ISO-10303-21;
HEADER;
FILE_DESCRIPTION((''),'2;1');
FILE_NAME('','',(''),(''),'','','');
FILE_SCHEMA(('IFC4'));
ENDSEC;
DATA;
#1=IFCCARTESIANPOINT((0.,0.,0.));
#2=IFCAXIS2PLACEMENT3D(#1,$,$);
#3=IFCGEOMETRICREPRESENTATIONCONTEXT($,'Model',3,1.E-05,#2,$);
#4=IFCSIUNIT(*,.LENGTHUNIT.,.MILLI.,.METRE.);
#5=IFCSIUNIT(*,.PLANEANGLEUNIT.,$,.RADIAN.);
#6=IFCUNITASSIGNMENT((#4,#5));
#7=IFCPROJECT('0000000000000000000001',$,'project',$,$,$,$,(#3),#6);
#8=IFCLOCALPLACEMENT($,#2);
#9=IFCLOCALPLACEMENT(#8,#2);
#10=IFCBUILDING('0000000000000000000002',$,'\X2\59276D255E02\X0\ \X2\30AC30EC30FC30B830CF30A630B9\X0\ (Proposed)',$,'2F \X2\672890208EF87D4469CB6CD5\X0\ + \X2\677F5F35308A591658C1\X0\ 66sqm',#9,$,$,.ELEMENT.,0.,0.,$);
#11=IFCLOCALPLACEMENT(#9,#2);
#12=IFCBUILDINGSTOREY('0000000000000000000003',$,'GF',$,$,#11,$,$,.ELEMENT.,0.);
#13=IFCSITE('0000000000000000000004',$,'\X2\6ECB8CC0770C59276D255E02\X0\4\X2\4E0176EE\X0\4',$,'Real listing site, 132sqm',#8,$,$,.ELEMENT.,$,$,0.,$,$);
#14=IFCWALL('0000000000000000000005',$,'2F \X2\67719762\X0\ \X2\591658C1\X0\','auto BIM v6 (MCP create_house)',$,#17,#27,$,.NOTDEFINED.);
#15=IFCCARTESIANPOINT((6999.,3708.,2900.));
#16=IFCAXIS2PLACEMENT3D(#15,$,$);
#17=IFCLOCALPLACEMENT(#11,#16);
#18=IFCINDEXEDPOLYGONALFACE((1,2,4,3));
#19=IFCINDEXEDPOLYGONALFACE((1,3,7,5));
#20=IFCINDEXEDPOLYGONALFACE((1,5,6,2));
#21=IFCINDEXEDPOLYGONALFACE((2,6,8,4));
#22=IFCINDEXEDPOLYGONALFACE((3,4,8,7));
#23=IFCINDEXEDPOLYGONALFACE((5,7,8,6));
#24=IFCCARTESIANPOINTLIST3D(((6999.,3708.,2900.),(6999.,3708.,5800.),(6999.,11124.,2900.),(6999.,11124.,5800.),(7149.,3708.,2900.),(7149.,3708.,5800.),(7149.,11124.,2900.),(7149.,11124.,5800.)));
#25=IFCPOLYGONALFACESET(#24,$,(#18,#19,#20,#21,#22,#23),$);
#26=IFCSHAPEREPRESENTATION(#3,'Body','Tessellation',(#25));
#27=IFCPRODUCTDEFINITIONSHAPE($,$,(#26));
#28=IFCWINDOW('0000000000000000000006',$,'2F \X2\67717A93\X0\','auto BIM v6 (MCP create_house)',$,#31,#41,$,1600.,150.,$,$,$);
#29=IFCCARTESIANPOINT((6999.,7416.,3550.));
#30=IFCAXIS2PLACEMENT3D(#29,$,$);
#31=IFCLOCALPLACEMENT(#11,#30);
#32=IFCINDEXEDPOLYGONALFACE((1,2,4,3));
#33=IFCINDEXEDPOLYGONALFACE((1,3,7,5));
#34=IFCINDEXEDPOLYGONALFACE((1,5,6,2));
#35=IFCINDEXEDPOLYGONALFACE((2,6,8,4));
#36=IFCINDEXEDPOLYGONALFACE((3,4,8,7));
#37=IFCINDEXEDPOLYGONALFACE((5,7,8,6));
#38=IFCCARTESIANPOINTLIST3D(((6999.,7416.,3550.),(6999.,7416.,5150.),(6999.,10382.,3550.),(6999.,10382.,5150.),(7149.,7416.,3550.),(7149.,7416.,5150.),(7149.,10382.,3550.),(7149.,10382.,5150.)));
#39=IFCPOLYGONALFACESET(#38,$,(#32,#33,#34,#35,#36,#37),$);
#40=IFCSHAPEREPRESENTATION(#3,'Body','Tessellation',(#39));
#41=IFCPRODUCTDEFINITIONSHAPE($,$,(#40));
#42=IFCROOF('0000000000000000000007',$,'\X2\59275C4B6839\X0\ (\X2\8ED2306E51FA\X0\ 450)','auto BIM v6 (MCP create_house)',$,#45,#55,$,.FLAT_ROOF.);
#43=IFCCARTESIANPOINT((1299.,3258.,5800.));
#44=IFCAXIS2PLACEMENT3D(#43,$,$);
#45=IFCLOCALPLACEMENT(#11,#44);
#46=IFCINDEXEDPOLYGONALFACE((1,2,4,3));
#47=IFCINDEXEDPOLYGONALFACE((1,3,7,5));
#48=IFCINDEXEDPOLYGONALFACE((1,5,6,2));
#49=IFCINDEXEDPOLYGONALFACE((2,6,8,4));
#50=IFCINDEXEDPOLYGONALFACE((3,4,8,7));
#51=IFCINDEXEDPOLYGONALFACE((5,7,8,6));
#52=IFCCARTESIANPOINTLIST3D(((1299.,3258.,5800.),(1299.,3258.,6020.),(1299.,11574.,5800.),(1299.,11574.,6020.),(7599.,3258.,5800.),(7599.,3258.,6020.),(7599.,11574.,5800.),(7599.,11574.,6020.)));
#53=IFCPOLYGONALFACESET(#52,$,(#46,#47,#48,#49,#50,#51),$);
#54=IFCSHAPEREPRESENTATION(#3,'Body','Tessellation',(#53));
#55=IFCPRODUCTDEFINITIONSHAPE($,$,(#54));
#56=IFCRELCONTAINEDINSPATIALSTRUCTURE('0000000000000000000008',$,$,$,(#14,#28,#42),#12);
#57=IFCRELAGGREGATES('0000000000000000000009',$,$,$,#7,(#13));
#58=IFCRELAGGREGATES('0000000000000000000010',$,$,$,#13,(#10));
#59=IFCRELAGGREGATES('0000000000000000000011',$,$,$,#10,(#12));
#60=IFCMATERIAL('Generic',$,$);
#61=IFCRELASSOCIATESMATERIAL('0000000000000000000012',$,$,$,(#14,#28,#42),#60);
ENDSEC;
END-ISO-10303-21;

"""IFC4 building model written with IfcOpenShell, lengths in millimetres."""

from ifc_helpers import new_model, si_unit, frame, frame_2d, origin, place, context, project, spatial, rectangle, extrude, material, element, fill, save


model = new_model("IFC4")

# Units and contexts
model_context = context("Model", 3, precision=1e-05, world=origin())
ifc_project = project(units=[si_unit("LENGTHUNIT", "METRE", prefix="MILLI"), si_unit("PLANEANGLEUNIT", "RADIAN")], contexts=[model_context])

# Site, building, storey
site_placement = place(None, origin())
site = spatial("IfcSite", under=ifc_project, at=site_placement, Name="滋賀県大津市4丁目4", ObjectType="Real listing site, 132sqm", CompositionType="ELEMENT", RefElevation=0.0)
building_placement = place(site_placement, origin())
building = spatial("IfcBuilding", under=site, at=building_placement, Name="大津市 ガレージハウス (Proposed)", ObjectType="2F 木造軸組構法 + 板張り外壁 66sqm", CompositionType="ELEMENT", ElevationOfRefHeight=0.0, ElevationOfTerrain=0.0)
storey_placement = place(building_placement, origin())
storey = spatial("IfcBuildingStorey", under=building, at=storey_placement, Name="GF", CompositionType="ELEMENT", Elevation=0.0)

# Shared definitions
ifc_material = material(Name="Generic")

# Wall, opening, window
wall_1_placement = place(storey_placement, frame((6999.0, 3708.0, 2900.0)))
wall_1 = element("IfcWall", 1, at=wall_1_placement, inside=storey, material=ifc_material, Name="2F 東面 外壁", Description="auto BIM v6 (MCP create_house)", PredefinedType="NOTDEFINED", context=model_context, shape_type="SweptSolid", body=[
    extrude(rectangle(XDim=150.0, YDim=7416.0, at=frame_2d((75.0, 3708.0))), frame((6999.0, 3708.0, 2900.0)), (0.0, 0.0, 1.0), 2900.0),
])
opening_1_placement = place(storey_placement, frame((6999.0, 7416.0, 3550.0)))
opening_1 = element("IfcOpeningElement", 2, at=opening_1_placement, cuts=wall_1, PredefinedType="NOTDEFINED", context=model_context, shape_type="SweptSolid", body=[
    extrude(rectangle(XDim=150.0, YDim=2966.0, at=frame_2d((75.0, 1483.0))), frame((6999.0, 7416.0, 3550.0)), (0.0, 0.0, 1.0), 1600.0),
])
window_1_placement = place(storey_placement, frame((6999.0, 7416.0, 3550.0)))
window_1 = element("IfcWindow", 3, at=window_1_placement, inside=storey, material=ifc_material, Name="2F 東窓", Description="auto BIM v6 (MCP create_house)", OverallHeight=1600.0, OverallWidth=150.0, context=model_context, shape_type="SweptSolid", body=[
    extrude(rectangle(XDim=150.0, YDim=2966.0, at=frame_2d((75.0, 1483.0))), frame((6999.0, 7416.0, 3550.0)), (0.0, 0.0, 1.0), 1600.0),
])
fill(opening_1, window_1)

# Roof
roof_placement = place(storey_placement, frame((1299.0, 3258.0, 5800.0)))
element("IfcRoof", 4, at=roof_placement, inside=storey, material=ifc_material, Name="大屋根 (軒の出 450)", Description="auto BIM v6 (MCP create_house)", PredefinedType="FLAT_ROOF", context=model_context, shape_type="SweptSolid", body=[
    extrude(rectangle(XDim=6300.0, YDim=8316.0, at=frame_2d((3150.0, 4158.0))), frame((1299.0, 3258.0, 5800.0)), (0.0, 0.0, 1.0), 220.0),
])

save(model, "model.ifc")
